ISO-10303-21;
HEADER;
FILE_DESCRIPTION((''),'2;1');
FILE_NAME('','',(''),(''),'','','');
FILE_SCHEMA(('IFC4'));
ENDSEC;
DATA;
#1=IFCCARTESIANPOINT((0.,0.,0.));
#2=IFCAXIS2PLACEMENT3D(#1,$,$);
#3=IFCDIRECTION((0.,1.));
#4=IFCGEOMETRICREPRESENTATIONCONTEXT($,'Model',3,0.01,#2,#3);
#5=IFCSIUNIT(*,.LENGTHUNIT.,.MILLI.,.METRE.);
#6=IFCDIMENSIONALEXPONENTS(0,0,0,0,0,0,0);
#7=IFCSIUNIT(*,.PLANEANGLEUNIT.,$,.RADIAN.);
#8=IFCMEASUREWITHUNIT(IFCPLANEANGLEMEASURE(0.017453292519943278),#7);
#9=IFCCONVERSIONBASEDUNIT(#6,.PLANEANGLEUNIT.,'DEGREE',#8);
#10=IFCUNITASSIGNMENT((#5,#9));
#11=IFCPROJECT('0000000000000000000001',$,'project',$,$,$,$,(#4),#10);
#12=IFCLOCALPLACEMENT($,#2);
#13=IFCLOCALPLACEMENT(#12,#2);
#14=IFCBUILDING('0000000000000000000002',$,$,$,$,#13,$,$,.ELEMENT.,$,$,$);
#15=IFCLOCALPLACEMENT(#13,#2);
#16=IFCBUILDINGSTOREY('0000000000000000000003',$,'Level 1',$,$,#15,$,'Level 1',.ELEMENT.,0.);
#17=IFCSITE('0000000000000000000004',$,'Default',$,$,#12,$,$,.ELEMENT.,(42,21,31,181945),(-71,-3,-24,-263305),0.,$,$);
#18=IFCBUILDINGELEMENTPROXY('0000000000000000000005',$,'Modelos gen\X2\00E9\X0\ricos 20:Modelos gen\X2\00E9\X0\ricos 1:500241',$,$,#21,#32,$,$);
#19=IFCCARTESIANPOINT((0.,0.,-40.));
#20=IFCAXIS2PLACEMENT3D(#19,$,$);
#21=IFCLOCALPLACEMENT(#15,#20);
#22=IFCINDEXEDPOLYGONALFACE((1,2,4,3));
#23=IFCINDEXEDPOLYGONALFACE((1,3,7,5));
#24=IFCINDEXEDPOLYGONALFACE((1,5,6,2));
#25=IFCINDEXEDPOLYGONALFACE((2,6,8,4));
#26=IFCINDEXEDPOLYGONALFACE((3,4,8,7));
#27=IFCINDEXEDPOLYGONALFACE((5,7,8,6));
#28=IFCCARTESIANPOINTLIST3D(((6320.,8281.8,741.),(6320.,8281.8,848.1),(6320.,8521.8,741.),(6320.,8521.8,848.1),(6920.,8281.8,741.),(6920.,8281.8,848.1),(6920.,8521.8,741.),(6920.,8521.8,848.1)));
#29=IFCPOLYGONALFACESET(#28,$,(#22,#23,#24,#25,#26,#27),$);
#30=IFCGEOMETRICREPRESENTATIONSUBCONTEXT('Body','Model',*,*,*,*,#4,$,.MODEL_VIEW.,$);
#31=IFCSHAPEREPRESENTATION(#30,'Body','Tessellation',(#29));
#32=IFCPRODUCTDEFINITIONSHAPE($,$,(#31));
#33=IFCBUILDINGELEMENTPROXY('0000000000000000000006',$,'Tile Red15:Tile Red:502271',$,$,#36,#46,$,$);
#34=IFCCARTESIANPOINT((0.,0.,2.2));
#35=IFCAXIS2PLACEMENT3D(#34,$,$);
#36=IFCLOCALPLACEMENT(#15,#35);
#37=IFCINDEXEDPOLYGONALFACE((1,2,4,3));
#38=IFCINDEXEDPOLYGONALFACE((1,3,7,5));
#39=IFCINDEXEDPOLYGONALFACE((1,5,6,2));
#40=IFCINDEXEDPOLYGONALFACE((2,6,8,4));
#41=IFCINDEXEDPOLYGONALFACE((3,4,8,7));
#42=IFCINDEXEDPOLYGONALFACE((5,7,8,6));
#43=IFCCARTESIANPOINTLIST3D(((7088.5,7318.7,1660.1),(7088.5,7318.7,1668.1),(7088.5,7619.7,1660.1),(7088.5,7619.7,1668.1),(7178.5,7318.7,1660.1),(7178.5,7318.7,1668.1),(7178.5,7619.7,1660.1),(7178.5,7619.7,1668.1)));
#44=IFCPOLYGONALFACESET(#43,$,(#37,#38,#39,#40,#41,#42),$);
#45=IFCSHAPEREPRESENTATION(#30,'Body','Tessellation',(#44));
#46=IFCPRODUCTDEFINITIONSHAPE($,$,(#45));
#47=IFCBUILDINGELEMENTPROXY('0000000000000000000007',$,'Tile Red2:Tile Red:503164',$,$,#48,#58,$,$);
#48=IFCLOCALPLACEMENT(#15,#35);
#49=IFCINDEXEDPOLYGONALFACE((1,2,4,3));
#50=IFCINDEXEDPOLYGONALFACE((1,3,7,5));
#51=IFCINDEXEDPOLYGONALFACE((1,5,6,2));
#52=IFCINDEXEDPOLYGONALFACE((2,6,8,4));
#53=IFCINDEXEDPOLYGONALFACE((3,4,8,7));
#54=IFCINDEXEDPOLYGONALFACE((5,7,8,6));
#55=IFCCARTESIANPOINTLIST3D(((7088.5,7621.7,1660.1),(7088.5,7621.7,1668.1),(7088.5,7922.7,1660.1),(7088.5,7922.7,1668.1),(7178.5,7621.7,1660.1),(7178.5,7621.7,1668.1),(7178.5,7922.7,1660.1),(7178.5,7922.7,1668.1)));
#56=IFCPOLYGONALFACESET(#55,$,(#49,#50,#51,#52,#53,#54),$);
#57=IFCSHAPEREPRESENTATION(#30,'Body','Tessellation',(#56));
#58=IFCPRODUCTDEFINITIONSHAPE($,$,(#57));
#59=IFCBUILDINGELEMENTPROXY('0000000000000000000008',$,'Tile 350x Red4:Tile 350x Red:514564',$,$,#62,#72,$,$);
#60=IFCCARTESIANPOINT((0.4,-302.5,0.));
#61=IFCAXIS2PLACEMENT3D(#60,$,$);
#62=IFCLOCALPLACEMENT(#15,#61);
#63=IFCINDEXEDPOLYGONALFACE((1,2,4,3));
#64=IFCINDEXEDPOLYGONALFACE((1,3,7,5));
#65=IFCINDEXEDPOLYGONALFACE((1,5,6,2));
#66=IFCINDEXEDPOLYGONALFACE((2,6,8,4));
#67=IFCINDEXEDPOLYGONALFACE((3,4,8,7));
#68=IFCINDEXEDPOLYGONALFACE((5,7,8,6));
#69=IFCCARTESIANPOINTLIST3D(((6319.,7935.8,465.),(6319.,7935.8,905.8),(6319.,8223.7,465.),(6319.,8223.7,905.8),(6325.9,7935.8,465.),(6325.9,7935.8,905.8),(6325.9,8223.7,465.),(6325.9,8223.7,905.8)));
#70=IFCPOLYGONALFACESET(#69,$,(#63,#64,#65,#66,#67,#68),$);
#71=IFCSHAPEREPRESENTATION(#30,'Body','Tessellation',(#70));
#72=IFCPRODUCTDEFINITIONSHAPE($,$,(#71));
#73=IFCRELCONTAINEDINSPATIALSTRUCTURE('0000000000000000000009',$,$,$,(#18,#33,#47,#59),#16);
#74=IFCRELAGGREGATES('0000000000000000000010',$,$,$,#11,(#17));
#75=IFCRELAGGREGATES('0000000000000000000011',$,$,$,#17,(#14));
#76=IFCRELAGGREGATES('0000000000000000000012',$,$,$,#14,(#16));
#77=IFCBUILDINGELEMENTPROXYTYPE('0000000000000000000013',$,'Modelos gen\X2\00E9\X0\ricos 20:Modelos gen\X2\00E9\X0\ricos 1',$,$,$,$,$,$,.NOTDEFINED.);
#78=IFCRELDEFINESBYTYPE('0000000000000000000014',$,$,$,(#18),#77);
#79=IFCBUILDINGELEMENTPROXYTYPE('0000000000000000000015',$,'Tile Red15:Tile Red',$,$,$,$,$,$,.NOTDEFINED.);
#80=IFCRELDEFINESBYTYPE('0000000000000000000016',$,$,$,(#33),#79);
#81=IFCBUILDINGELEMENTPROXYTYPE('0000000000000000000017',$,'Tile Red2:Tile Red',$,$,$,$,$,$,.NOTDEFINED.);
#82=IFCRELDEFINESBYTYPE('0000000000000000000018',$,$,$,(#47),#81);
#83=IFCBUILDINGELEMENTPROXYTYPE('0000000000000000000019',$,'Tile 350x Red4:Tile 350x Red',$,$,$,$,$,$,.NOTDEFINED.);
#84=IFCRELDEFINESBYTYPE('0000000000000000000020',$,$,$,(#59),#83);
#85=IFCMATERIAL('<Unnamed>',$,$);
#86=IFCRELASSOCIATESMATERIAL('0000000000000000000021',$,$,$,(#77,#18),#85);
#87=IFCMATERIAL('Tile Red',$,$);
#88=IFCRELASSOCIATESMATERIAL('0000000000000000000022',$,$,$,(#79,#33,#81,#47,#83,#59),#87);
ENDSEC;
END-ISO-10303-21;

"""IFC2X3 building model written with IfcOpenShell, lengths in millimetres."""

from ifc_helpers import new_model, entity, si_unit, converted_unit, direction, frame, frame_2d, origin, origin_2d_with_axis, place, context, subcontext, project, spatial, rectangle, extrude, source, transform, mapped, material, type_object, type_shapes, element, save


model = new_model("IFC2X3")

# Units and contexts
model_context = context("Model", 3, precision=0.01, world=origin(), true_north=direction((0.0, 1.0)))
body_context = subcontext(model_context, "Body", "Model", "MODEL_VIEW")
ifc_project = project(units=[si_unit("LENGTHUNIT", "METRE", prefix="MILLI"), converted_unit("PLANEANGLEUNIT", "DEGREE", entity("IfcPlaneAngleMeasure", 0.017453292519943278), si_unit("PLANEANGLEUNIT", "RADIAN"), dimensions=[0, 0, 0, 0, 0, 0, 0])], contexts=[model_context])

# Site, building, storey
site_placement = place(None, origin())
site = spatial("IfcSite", under=ifc_project, at=site_placement, Name="Default", CompositionType="ELEMENT", RefLatitude=(42, 21, 31, 181945), RefLongitude=(-71, -3, -24, -263305), RefElevation=0.0)
building_placement = place(site_placement, origin())
building = spatial("IfcBuilding", under=site, at=building_placement, CompositionType="ELEMENT")
storey_placement = place(building_placement, origin())
storey = spatial("IfcBuildingStorey", under=building, at=storey_placement, Name="Level 1", LongName="Level 1", CompositionType="ELEMENT", Elevation=0.0)

# Building element proxies
ifc_material_1 = material(Name="Tile Red")
ifc_material_2 = material(Name="<Unnamed>")
building_element_proxy_type_1 = type_object("IfcBuildingElementProxyType", Name="Modelos genéricos 20:Modelos genéricos 1", PredefinedType="NOTDEFINED", material=ifc_material_2)
shared_shape_1 = source(origin(), body_context, "Body", "SweptSolid", [
    extrude(rectangle(XDim=600.0, YDim=240.0, at=origin_2d_with_axis()), frame((6620.0, 8401.8, 741.0), z_axis=(0.0, 0.0, 1.0), x_axis=(-1.0, 0.0, 0.0)), (0.0, 0.0, 1.0), 107.1),
])
type_shapes(building_element_proxy_type_1, [shared_shape_1])
proxy_1_placement = place(storey_placement, frame((0.0, 0.0, -40.0)))
element("IfcBuildingElementProxy", 1, at=proxy_1_placement, inside=storey, type_object=building_element_proxy_type_1, material=ifc_material_2, Name="Modelos genéricos 20:Modelos genéricos 1:500241", context=body_context, shape_type="MappedRepresentation", body=[
    mapped(shared_shape_1, transform((0.0, 0.0, 0.0), scale=1.0)),
])
building_element_proxy_type_2 = type_object("IfcBuildingElementProxyType", Name="Tile Red15:Tile Red", PredefinedType="NOTDEFINED", material=ifc_material_1)
shared_shape_2 = source(origin(), body_context, "Body", "SweptSolid", [
    extrude(rectangle(XDim=90.0, YDim=301.0, at=frame_2d((0.0, 0.0), x_axis=(1.0, 0.0))), frame((7133.5, 7469.2, 1660.1)), (0.0, 0.0, 1.0), 8.0),
])
type_shapes(building_element_proxy_type_2, [shared_shape_2])
proxy_2_placement = place(storey_placement, frame((0.0, 0.0, 2.2)))
element("IfcBuildingElementProxy", 2, at=proxy_2_placement, inside=storey, type_object=building_element_proxy_type_2, material=ifc_material_1, Name="Tile Red15:Tile Red:502271", context=body_context, shape_type="MappedRepresentation", body=[
    mapped(shared_shape_2, transform((0.0, 0.0, 0.0), scale=1.0)),
])
building_element_proxy_type_3 = type_object("IfcBuildingElementProxyType", Name="Tile Red2:Tile Red", PredefinedType="NOTDEFINED", material=ifc_material_1)
shared_shape_3 = source(origin(), body_context, "Body", "SweptSolid", [
    extrude(rectangle(XDim=301.0, YDim=90.0, at=frame_2d((0.0, 0.0), x_axis=(1.0, 0.0))), frame((7133.5, 7772.2, 1660.1), z_axis=(0.0, 0.0, 1.0), x_axis=(0.0, -1.0, 0.0)), (0.0, 0.0, 1.0), 8.0),
])
type_shapes(building_element_proxy_type_3, [shared_shape_3])
proxy_3_placement = place(storey_placement, frame((0.0, 0.0, 2.2)))
element("IfcBuildingElementProxy", 3, at=proxy_3_placement, inside=storey, type_object=building_element_proxy_type_3, material=ifc_material_1, Name="Tile Red2:Tile Red:503164", context=body_context, shape_type="MappedRepresentation", body=[
    mapped(shared_shape_3, transform((0.0, 0.0, 0.0), scale=1.0)),
])
building_element_proxy_type_4 = type_object("IfcBuildingElementProxyType", Name="Tile 350x Red4:Tile 350x Red", PredefinedType="NOTDEFINED", material=ifc_material_1)
shared_shape_4 = source(origin(), body_context, "Body", "SweptSolid", [
    extrude(rectangle(XDim=6.9, YDim=287.9, at=frame_2d((0.0, 0.0), x_axis=(1.0, 0.0))), frame((6322.4, 8079.7, 465.0)), (0.0, 0.0, 1.0), 440.8),
])
type_shapes(building_element_proxy_type_4, [shared_shape_4])
proxy_4_placement = place(storey_placement, frame((0.4, -302.5, 0.0)))
element("IfcBuildingElementProxy", 4, at=proxy_4_placement, inside=storey, type_object=building_element_proxy_type_4, material=ifc_material_1, Name="Tile 350x Red4:Tile 350x Red:514564", context=body_context, shape_type="MappedRepresentation", body=[
    mapped(shared_shape_4, transform((0.0, 0.0, 0.0), scale=1.0)),
])

save(model, "model.ifc")
